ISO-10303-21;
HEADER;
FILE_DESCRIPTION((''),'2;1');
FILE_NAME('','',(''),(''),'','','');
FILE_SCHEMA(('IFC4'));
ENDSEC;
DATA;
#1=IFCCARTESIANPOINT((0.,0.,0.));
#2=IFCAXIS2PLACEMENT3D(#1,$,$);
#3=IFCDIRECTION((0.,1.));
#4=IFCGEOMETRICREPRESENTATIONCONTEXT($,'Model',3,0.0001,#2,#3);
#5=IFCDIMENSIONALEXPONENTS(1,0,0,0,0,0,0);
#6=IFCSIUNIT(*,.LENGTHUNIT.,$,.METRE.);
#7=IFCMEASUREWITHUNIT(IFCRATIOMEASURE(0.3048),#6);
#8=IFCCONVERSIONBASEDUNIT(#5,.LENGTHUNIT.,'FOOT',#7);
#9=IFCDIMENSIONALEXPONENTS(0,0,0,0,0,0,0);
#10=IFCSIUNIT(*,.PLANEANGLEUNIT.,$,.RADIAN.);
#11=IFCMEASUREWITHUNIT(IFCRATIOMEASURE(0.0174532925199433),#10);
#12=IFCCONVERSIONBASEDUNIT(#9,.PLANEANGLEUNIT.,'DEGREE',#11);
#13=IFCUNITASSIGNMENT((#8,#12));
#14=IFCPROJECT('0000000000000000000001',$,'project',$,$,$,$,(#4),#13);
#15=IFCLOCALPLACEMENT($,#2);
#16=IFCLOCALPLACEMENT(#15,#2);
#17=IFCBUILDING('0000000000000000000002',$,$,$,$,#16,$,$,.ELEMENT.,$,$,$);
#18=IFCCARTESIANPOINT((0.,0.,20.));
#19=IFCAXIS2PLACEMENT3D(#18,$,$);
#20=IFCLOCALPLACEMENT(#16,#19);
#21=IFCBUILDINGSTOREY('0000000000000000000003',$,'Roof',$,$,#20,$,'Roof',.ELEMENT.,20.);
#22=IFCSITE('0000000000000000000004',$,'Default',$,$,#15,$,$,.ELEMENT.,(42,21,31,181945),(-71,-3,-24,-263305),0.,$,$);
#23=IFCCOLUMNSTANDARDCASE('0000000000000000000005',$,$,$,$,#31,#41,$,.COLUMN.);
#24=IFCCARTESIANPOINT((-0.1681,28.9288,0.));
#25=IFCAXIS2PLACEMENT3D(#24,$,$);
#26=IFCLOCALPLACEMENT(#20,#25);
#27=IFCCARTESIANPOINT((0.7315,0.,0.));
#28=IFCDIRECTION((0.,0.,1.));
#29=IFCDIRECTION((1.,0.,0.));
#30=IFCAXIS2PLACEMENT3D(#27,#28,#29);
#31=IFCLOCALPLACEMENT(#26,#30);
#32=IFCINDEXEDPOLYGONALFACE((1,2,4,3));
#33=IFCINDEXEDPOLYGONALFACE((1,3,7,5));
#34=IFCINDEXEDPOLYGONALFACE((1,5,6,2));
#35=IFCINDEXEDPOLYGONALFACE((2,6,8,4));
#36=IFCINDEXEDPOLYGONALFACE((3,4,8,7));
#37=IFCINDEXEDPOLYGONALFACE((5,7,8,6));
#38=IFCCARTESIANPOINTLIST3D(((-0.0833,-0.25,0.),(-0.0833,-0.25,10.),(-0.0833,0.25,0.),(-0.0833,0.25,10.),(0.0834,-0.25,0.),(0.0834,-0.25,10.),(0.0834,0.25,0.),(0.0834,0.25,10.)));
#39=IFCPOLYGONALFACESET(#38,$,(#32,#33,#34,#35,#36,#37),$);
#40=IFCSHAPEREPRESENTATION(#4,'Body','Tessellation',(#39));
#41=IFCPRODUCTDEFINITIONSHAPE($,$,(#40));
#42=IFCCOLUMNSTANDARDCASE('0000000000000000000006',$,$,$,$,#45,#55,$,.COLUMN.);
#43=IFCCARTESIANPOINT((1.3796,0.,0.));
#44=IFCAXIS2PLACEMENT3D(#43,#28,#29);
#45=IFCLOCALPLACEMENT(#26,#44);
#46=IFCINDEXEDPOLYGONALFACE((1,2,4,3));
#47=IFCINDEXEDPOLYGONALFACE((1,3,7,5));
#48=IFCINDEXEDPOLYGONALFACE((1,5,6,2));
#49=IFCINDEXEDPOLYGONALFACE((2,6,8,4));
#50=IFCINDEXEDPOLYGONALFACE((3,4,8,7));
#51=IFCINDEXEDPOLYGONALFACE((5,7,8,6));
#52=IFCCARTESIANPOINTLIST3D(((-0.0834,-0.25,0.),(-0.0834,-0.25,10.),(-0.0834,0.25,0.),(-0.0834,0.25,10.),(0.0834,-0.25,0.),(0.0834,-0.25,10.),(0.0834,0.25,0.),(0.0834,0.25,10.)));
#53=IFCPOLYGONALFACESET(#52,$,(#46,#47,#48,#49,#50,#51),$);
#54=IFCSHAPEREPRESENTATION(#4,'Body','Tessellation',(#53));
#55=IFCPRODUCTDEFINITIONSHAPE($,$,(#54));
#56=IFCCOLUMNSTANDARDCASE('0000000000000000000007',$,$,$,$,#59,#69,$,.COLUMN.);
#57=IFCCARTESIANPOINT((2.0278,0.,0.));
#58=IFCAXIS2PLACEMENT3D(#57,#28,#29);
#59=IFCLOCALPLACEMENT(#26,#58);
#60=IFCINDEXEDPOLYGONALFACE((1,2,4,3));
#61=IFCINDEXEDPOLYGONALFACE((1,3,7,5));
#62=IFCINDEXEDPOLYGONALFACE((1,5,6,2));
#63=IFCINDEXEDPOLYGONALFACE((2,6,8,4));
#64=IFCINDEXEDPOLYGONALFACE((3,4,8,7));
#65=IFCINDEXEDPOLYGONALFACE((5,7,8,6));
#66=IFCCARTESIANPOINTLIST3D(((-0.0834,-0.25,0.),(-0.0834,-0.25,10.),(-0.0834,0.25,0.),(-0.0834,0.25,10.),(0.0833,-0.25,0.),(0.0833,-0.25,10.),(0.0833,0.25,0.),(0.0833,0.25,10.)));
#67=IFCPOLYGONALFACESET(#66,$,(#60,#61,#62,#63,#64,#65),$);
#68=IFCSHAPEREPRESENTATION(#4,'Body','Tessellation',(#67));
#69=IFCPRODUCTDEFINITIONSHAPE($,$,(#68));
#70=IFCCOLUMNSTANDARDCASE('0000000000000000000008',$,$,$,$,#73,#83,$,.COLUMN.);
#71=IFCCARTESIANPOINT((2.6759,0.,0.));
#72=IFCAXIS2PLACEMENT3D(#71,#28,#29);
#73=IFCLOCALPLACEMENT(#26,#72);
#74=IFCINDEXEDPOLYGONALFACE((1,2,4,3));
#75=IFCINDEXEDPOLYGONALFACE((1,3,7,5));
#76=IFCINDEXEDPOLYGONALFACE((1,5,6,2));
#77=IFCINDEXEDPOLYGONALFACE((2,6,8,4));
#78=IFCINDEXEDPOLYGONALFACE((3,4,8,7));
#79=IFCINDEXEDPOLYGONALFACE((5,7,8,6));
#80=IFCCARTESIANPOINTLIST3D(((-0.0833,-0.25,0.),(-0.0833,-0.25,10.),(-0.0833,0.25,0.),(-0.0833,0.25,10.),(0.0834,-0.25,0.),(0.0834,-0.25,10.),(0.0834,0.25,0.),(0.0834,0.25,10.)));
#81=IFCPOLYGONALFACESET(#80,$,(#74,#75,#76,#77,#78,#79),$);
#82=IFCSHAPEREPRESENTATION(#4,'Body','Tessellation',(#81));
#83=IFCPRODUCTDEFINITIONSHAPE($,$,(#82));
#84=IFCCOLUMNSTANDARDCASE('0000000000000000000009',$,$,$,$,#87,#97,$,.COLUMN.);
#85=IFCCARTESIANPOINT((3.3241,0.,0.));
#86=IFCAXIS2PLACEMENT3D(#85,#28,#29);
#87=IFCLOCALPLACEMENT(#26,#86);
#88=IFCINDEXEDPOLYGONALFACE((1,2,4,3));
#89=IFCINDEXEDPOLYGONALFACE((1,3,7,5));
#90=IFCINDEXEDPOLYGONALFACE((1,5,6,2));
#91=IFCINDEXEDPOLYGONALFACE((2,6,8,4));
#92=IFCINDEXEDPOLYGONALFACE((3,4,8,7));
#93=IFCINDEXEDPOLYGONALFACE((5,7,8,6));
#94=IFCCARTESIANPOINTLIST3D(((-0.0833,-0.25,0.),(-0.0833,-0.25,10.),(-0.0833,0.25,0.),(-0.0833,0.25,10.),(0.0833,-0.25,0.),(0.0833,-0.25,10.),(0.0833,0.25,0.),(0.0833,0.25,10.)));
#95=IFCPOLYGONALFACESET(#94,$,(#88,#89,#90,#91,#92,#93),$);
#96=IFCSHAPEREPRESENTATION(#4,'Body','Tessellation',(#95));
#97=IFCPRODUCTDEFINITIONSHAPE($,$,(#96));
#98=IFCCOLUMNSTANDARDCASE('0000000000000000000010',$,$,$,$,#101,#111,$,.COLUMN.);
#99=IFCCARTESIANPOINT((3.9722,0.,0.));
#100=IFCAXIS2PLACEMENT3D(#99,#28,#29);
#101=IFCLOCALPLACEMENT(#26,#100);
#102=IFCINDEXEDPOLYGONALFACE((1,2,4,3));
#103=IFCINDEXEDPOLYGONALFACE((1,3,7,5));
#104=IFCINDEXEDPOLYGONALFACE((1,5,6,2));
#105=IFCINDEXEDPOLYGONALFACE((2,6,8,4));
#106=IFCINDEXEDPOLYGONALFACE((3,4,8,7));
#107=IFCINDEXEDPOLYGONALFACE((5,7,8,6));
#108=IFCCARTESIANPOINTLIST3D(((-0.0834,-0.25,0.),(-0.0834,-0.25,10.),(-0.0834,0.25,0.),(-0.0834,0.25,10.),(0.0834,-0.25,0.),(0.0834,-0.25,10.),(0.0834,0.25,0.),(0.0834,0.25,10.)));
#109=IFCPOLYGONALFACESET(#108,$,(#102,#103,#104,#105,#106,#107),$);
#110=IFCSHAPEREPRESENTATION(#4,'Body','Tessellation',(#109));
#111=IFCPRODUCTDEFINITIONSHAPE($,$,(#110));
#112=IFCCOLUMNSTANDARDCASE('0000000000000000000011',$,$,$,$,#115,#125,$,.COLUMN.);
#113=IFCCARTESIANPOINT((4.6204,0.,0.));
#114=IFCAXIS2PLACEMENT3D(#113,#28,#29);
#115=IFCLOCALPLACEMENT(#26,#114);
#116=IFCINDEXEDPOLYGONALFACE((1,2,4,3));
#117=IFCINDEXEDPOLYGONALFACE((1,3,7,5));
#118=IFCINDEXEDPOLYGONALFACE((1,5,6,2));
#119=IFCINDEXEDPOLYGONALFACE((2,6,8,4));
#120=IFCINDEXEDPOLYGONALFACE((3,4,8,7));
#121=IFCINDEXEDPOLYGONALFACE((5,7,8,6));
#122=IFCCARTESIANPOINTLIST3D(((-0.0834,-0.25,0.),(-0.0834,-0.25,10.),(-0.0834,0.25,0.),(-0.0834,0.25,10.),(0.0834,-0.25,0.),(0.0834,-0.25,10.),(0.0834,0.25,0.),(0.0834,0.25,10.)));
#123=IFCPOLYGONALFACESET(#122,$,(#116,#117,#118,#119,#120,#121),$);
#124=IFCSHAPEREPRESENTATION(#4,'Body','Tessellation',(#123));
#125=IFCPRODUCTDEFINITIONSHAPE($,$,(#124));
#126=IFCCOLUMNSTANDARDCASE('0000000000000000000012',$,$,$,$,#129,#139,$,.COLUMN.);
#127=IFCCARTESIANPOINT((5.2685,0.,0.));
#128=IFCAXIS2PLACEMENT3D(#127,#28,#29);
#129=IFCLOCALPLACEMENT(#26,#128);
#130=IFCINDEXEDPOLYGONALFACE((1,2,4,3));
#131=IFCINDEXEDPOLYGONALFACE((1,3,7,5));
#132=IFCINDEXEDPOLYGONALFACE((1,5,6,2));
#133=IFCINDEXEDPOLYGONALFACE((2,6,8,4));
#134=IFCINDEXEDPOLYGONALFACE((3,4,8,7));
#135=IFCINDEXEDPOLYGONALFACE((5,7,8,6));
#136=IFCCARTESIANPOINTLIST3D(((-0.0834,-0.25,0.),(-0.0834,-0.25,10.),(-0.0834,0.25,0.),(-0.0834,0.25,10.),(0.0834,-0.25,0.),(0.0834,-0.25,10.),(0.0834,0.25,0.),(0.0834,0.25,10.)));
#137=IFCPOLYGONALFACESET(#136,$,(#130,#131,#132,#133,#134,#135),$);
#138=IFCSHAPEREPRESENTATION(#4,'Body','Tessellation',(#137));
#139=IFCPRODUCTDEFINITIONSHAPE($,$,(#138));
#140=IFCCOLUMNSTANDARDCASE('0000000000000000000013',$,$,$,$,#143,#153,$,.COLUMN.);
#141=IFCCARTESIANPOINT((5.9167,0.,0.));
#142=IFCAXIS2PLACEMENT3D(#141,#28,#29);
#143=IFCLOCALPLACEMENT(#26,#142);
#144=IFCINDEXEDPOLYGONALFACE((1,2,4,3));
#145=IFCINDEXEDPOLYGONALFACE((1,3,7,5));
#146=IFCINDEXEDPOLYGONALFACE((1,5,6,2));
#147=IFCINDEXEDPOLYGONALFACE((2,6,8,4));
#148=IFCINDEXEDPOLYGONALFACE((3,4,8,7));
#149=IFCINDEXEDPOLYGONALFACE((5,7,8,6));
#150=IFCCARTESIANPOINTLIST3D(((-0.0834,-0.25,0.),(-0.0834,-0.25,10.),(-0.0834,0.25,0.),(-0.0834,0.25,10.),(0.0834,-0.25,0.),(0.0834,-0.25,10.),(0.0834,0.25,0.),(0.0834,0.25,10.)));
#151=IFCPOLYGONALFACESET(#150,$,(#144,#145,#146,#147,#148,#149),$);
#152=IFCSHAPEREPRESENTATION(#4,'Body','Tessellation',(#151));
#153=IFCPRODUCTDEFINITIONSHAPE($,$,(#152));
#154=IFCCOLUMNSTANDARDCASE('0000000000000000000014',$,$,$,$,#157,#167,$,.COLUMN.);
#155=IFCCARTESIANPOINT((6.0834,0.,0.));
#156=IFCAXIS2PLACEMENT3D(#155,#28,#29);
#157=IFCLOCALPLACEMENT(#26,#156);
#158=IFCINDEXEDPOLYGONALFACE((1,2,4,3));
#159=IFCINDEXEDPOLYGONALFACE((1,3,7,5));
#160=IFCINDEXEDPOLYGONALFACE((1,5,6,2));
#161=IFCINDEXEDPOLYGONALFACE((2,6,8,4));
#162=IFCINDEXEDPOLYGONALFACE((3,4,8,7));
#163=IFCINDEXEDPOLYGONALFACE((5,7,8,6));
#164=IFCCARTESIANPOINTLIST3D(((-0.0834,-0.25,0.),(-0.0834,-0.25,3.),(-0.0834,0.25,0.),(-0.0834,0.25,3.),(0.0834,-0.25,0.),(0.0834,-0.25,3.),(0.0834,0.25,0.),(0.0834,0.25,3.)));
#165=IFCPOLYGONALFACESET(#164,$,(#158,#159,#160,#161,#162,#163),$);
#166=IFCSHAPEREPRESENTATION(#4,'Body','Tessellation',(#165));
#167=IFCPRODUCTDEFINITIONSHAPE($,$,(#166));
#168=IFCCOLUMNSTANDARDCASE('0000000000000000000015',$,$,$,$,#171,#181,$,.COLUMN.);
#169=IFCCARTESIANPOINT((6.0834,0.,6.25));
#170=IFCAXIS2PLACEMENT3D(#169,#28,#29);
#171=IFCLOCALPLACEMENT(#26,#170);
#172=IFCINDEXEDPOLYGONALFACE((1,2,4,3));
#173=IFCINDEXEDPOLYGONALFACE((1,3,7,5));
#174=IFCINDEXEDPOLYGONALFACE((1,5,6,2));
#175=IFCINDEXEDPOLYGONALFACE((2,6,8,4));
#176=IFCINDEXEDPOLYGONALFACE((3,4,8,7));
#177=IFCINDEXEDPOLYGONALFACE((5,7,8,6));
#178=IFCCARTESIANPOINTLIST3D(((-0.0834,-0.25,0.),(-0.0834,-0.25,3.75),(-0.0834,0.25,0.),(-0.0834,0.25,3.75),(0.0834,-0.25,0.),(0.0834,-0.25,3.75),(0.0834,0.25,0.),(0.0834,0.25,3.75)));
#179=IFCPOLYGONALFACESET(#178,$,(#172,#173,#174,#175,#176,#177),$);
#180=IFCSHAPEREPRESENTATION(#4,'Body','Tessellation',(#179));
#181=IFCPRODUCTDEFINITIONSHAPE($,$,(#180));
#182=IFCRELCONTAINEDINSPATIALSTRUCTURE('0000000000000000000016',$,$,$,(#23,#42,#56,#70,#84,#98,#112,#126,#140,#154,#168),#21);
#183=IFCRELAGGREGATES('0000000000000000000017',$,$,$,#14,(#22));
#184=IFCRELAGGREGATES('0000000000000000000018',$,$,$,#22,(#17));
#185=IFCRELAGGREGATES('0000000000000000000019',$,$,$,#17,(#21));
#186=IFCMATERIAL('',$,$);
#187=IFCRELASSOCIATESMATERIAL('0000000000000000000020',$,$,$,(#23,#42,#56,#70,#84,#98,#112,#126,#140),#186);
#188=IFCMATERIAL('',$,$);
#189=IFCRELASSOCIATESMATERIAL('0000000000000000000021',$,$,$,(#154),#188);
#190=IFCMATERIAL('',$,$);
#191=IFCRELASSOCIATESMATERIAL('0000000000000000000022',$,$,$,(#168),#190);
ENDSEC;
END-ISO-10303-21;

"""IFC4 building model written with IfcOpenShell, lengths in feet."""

from ifc_helpers import new_model, entity, si_unit, converted_unit, direction, frame, origin, place, context, project, spatial, rectangle, extrude, material, element, save


model = new_model("IFC4")

# Units and contexts
model_context = context("Model", 3, precision=0.0001, world=origin(), true_north=direction((0.0, 1.0)))
ifc_project = project(units=[converted_unit("LENGTHUNIT", "FOOT", entity("IfcRatioMeasure", 0.3048), si_unit("LENGTHUNIT", "METRE"), dimensions=[1, 0, 0, 0, 0, 0, 0]), converted_unit("PLANEANGLEUNIT", "DEGREE", entity("IfcRatioMeasure", 0.0174532925199433), si_unit("PLANEANGLEUNIT", "RADIAN"), dimensions=[0, 0, 0, 0, 0, 0, 0])], contexts=[model_context])

# Site, building, storey
site_placement = place(None, origin())
site = spatial("IfcSite", under=ifc_project, at=site_placement, Name="Default", CompositionType="ELEMENT", RefLatitude=(42, 21, 31, 181945), RefLongitude=(-71, -3, -24, -263305), RefElevation=0.0)
building_placement = place(site_placement, origin())
building = spatial("IfcBuilding", under=site, at=building_placement, CompositionType="ELEMENT")
storey_placement = place(building_placement, frame((0.0, 0.0, 20.0)))
storey = spatial("IfcBuildingStorey", under=building, at=storey_placement, Name="Roof", LongName="Roof", CompositionType="ELEMENT", Elevation=20.0)

# Columns
ifc_material_1 = material(Name="")
placement = place(storey_placement, frame((-0.1681, 28.9288, 0.0)))
for number, where, z_axis, x_axis in (
    (1, (0.7315, 0.0, 0.0), (0.0, 0.0, 1.0), (1.0, 0.0, 0.0)),
    (2, (1.3796, 0.0, 0.0), (0.0, 0.0, 1.0), (1.0, 0.0, 0.0)),
    (3, (2.0278, 0.0, 0.0), (0.0, 0.0, 1.0), (1.0, 0.0, 0.0)),
    (4, (2.6759, 0.0, 0.0), (0.0, 0.0, 1.0), (1.0, 0.0, 0.0)),
    (5, (3.3241, 0.0, 0.0), (0.0, 0.0, 1.0), (1.0, 0.0, 0.0)),
    (6, (3.9722, 0.0, 0.0), (0.0, 0.0, 1.0), (1.0, 0.0, 0.0)),
    (7, (4.6204, 0.0, 0.0), (0.0, 0.0, 1.0), (1.0, 0.0, 0.0)),
    (8, (5.2685, 0.0, 0.0), (0.0, 0.0, 1.0), (1.0, 0.0, 0.0)),
    (9, (5.9167, 0.0, 0.0), (0.0, 0.0, 1.0), (1.0, 0.0, 0.0)),
):
    element("IfcColumnStandardCase", number, at=place(placement, frame(where, z_axis=z_axis, x_axis=x_axis)), inside=storey, material=ifc_material_1, PredefinedType="COLUMN", context=model_context, shape_type="SweptSolid", body=[
        extrude(rectangle(XDim=0.1667, YDim=0.5), origin(), (0.0, 0.0, 1.0), 10.0),
    ])
ifc_material_2 = material(Name="")
for number, where, z_axis, x_axis in (
    (10, (6.0834, 0.0, 0.0), (0.0, 0.0, 1.0), (1.0, 0.0, 0.0)),
):
    element("IfcColumnStandardCase", number, at=place(placement, frame(where, z_axis=z_axis, x_axis=x_axis)), inside=storey, material=ifc_material_2, PredefinedType="COLUMN", context=model_context, shape_type="SweptSolid", body=[
        extrude(rectangle(XDim=0.1667, YDim=0.5), origin(), (0.0, 0.0, 1.0), 3.0),
    ])
ifc_material_3 = material(Name="")
for number, where, z_axis, x_axis in (
    (11, (6.0834, 0.0, 6.25), (0.0, 0.0, 1.0), (1.0, 0.0, 0.0)),
):
    element("IfcColumnStandardCase", number, at=place(placement, frame(where, z_axis=z_axis, x_axis=x_axis)), inside=storey, material=ifc_material_3, PredefinedType="COLUMN", context=model_context, shape_type="SweptSolid", body=[
        extrude(rectangle(XDim=0.1667, YDim=0.5), origin(), (0.0, 0.0, 1.0), 3.75),
    ])

save(model, "model.ifc")
